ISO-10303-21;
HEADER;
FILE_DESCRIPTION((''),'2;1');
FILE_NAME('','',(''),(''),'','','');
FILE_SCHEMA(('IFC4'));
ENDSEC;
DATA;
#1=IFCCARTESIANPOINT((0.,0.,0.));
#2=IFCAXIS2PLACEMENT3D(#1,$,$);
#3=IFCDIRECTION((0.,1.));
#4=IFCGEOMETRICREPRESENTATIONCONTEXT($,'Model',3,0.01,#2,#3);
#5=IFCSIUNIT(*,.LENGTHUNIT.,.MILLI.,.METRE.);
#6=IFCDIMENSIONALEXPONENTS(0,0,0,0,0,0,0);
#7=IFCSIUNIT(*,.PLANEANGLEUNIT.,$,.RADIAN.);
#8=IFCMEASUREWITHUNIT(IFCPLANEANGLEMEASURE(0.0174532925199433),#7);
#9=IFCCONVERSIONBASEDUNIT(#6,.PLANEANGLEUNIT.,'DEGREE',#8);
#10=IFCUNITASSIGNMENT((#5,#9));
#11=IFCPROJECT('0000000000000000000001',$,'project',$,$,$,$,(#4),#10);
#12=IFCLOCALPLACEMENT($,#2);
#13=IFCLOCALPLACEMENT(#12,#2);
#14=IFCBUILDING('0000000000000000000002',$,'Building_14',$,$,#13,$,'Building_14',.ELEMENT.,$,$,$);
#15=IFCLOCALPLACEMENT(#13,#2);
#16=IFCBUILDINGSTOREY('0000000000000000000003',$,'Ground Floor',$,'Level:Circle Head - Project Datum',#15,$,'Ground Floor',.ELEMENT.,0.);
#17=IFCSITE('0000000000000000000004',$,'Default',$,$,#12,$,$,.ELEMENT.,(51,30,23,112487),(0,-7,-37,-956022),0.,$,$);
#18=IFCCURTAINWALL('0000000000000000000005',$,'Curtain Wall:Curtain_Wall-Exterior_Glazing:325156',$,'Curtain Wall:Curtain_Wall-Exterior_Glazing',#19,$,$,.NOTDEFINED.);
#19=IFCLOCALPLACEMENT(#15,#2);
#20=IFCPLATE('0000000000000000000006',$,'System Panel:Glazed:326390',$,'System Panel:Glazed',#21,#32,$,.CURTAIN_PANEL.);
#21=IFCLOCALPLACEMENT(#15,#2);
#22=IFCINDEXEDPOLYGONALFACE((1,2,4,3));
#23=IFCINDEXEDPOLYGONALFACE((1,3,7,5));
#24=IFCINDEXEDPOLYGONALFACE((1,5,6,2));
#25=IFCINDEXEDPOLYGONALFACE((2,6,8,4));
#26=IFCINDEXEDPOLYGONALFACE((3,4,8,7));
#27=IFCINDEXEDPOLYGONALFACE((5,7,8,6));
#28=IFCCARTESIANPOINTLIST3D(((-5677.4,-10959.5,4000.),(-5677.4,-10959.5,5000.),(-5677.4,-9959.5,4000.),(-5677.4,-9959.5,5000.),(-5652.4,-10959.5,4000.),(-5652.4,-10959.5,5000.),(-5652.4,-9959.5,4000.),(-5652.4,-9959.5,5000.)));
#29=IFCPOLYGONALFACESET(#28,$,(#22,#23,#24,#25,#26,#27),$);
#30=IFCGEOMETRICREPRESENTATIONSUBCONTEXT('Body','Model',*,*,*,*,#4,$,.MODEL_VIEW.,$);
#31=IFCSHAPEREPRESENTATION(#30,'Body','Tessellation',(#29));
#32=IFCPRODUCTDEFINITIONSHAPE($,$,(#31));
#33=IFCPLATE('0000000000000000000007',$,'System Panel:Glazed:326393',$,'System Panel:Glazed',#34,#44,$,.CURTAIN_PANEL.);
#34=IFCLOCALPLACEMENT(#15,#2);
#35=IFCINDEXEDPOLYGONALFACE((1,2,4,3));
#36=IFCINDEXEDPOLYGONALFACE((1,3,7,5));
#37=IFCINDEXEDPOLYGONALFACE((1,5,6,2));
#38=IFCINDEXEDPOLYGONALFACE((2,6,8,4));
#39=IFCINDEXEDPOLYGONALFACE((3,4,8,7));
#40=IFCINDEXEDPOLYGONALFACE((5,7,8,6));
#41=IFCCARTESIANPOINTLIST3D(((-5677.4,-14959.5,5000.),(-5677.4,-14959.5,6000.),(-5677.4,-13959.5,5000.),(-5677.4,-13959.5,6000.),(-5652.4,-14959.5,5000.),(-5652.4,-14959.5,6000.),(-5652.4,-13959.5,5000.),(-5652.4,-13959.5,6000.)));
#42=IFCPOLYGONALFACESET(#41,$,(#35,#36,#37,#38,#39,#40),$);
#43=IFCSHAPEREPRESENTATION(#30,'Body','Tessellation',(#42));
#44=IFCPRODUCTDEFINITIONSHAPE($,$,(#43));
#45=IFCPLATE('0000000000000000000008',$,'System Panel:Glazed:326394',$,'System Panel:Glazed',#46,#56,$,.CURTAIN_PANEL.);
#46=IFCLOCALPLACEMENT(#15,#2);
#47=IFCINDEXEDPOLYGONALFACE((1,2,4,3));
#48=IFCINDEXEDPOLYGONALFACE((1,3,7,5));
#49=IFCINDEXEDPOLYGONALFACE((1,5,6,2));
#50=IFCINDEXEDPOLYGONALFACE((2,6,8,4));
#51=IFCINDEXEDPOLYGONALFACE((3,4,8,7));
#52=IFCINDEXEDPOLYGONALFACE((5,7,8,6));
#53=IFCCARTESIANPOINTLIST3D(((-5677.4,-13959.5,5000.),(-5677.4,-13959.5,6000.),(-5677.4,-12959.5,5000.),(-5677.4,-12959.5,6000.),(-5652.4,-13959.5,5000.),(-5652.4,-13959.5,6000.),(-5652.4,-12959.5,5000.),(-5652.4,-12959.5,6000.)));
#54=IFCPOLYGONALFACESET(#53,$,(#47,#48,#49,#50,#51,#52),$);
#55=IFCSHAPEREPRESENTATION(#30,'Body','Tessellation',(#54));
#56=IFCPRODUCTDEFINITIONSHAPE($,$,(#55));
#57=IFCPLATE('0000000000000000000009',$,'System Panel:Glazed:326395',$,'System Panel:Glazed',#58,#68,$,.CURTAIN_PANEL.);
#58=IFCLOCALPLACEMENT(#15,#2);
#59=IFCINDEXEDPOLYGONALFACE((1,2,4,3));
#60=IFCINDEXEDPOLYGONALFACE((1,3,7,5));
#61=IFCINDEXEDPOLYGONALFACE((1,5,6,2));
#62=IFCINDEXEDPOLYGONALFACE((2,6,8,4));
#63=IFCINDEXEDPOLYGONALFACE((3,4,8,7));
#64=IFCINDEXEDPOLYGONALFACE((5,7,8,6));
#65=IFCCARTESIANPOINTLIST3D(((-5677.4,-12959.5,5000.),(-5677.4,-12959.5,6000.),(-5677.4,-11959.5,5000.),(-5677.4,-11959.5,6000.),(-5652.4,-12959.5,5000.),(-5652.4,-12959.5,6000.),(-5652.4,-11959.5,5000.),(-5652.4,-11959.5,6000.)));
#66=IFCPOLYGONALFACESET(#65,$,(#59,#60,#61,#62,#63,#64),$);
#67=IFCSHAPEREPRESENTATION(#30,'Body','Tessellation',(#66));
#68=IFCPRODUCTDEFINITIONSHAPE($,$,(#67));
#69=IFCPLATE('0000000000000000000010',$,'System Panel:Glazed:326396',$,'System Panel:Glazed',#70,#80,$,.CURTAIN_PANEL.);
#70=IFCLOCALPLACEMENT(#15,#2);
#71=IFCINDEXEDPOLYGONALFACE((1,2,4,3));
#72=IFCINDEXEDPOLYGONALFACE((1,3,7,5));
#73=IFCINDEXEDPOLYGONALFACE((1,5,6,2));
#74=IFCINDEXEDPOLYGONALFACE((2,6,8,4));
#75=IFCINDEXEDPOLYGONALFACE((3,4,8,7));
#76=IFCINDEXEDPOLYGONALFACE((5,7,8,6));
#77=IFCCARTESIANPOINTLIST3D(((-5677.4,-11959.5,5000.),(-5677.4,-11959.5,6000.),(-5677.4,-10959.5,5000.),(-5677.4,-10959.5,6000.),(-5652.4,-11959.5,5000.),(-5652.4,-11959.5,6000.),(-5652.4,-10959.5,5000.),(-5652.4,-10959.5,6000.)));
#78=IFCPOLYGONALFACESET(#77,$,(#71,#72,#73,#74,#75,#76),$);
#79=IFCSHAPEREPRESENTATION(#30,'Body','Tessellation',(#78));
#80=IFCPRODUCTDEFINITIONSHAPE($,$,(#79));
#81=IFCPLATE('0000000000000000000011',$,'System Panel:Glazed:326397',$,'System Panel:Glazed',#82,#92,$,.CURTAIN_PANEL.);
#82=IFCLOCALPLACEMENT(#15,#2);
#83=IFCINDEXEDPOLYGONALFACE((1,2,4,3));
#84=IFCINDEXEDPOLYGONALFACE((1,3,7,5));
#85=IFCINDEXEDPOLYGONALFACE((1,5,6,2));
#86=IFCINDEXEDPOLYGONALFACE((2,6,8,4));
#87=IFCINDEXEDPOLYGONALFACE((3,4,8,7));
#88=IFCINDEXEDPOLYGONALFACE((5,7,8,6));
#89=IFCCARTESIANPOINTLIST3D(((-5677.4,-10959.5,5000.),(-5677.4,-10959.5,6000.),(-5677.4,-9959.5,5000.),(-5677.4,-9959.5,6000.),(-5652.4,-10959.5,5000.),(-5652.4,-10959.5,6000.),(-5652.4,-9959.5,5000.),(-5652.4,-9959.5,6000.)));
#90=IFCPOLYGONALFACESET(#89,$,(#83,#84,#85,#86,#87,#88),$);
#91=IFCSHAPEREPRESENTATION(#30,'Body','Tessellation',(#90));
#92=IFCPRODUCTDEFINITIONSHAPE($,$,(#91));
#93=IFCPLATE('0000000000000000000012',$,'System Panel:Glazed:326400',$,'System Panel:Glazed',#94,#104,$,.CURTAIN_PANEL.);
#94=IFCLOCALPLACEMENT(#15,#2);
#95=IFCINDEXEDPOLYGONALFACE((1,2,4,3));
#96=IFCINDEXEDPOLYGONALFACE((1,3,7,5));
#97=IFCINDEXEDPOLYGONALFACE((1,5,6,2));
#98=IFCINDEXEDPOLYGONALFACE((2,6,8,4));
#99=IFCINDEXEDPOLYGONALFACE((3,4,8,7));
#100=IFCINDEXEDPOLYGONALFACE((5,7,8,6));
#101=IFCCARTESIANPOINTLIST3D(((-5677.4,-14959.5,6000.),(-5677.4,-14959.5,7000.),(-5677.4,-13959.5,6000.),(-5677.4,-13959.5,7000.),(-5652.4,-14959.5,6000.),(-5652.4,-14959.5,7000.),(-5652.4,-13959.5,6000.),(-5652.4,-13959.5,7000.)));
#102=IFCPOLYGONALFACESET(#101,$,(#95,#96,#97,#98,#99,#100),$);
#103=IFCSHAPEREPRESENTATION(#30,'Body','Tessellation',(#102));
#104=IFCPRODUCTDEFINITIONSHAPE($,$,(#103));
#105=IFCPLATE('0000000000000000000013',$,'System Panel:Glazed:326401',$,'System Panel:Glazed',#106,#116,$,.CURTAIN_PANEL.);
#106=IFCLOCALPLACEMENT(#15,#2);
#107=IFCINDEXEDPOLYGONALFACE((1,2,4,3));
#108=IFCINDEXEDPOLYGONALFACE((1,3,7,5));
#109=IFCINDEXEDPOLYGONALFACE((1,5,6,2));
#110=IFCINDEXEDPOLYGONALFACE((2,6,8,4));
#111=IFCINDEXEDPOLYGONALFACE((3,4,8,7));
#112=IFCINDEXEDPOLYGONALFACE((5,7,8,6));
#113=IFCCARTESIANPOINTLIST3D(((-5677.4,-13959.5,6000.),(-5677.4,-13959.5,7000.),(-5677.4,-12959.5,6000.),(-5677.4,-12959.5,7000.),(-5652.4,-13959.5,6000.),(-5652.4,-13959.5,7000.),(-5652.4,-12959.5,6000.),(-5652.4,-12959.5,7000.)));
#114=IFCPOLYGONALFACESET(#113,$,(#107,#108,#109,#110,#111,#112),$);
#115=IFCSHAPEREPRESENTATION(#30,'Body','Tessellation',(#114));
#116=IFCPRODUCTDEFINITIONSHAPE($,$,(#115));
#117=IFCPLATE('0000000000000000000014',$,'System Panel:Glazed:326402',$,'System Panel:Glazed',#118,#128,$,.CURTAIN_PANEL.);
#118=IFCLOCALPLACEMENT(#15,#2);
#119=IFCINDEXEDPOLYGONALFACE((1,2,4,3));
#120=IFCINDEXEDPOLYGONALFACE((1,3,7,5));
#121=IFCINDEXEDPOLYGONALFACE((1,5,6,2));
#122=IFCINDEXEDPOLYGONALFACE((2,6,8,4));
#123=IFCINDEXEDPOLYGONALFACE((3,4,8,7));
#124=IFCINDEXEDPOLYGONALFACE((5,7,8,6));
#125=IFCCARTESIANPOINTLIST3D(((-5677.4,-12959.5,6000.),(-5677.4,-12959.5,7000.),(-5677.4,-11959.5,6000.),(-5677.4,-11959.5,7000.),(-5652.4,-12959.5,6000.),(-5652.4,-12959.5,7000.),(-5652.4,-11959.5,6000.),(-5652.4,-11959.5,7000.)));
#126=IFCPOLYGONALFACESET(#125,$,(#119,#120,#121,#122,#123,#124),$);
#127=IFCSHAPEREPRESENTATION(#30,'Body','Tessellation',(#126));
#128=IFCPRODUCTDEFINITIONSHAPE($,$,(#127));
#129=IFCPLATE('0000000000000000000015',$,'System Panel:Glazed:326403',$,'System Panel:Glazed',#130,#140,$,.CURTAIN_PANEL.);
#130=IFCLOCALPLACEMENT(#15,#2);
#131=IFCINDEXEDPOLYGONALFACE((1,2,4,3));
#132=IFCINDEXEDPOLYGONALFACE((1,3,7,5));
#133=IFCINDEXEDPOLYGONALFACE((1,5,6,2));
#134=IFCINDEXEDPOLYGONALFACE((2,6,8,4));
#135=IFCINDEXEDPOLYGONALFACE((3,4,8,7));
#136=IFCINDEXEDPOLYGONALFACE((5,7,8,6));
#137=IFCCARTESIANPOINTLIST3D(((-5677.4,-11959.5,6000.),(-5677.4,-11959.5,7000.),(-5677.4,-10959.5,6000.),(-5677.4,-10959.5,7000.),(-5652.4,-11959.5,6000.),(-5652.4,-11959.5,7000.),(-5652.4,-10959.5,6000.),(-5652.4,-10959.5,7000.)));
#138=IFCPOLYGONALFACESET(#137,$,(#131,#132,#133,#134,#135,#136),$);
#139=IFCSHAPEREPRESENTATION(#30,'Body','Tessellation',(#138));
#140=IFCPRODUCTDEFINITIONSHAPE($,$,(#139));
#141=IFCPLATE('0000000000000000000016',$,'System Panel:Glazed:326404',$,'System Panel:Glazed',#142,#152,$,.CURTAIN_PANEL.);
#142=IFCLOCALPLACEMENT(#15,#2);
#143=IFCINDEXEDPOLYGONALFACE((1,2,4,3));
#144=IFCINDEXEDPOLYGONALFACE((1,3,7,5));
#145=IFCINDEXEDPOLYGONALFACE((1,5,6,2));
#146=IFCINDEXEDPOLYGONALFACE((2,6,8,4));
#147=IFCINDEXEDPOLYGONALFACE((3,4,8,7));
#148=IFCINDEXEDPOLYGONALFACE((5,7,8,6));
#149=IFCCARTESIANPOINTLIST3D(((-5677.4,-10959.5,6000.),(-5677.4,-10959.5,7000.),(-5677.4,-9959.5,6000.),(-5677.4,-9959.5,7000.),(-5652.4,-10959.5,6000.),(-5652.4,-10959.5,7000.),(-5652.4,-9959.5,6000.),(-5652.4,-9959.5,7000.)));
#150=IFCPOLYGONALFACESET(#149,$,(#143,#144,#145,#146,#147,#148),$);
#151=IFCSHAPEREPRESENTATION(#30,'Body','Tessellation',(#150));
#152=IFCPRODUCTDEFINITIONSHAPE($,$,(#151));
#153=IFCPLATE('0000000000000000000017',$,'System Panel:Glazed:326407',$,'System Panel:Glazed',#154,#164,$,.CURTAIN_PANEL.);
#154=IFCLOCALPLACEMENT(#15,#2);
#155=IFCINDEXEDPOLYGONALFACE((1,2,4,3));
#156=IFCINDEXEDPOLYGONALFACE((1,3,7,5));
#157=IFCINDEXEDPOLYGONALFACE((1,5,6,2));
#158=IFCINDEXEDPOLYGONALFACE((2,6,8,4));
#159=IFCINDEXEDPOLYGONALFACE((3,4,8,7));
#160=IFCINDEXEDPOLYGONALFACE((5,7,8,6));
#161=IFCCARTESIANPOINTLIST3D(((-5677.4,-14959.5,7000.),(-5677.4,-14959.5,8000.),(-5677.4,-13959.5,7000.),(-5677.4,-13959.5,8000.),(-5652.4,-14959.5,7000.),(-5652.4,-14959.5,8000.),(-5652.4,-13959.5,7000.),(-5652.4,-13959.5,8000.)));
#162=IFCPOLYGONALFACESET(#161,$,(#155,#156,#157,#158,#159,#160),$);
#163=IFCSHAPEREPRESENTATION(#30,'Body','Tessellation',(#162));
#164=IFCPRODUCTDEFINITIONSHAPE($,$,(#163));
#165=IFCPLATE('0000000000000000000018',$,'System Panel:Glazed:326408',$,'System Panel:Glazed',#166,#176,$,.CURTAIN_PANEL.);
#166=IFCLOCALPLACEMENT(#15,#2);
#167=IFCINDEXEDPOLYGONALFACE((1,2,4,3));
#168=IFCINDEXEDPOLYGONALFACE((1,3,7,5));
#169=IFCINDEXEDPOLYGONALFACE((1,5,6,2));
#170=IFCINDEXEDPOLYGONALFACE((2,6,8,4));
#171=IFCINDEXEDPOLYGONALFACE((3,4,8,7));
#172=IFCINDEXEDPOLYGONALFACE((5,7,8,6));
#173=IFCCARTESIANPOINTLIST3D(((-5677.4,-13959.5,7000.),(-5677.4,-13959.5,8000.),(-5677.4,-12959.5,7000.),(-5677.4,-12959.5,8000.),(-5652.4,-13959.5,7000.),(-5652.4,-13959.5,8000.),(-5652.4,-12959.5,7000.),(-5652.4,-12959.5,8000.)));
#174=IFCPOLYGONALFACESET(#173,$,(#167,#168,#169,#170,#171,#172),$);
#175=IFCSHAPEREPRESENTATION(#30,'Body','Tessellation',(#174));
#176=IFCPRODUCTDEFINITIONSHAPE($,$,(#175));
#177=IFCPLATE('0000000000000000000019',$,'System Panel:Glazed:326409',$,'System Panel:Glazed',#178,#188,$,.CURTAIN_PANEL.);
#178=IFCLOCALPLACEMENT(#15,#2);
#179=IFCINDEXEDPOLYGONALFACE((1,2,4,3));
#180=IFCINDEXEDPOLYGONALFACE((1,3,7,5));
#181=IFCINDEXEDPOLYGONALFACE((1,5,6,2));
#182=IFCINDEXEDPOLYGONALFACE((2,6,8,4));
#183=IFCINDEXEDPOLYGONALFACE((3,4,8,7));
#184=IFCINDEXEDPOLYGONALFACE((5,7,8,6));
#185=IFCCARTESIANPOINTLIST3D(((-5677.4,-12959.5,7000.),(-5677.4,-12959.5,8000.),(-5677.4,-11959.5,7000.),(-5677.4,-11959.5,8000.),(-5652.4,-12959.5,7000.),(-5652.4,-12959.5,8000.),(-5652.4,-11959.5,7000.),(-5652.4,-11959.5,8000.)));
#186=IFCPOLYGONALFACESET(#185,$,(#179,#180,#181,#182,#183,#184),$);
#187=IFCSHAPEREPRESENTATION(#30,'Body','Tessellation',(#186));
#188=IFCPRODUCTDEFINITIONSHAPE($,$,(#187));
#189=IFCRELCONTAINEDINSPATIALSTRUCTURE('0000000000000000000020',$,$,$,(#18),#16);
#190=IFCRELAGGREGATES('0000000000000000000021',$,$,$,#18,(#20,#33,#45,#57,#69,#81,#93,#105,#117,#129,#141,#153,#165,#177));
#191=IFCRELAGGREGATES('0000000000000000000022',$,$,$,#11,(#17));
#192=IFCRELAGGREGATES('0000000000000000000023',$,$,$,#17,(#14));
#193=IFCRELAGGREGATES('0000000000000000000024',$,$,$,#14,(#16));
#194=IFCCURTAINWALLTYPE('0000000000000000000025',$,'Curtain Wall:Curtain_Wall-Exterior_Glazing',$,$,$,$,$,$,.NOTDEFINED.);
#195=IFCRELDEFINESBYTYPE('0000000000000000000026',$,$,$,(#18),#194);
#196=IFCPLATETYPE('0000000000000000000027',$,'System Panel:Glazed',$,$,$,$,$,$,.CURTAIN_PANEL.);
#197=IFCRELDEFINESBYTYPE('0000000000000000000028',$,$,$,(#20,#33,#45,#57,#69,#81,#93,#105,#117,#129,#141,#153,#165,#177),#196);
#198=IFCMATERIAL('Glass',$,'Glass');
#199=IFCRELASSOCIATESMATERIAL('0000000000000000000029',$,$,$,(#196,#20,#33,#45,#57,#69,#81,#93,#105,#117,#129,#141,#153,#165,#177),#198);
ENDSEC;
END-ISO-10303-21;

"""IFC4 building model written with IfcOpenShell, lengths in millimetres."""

from ifc_helpers import new_model, entity, si_unit, converted_unit, direction, frame, origin, place, context, subcontext, project, spatial, indexed_curve, outline, extrude, source, transform, mapped, material, type_object, type_shapes, element, aggregate, save


model = new_model("IFC4")

# Units and contexts
model_context = context("Model", 3, precision=0.01, world=origin(), true_north=direction((0.0, 1.0)))
body_context = subcontext(model_context, "Body", "Model", "MODEL_VIEW")
ifc_project = project(units=[si_unit("LENGTHUNIT", "METRE", prefix="MILLI"), converted_unit("PLANEANGLEUNIT", "DEGREE", entity("IfcPlaneAngleMeasure", 0.0174532925199433), si_unit("PLANEANGLEUNIT", "RADIAN"), dimensions=[0, 0, 0, 0, 0, 0, 0])], contexts=[model_context])

# Site, building, storey
site_placement = place(None, origin())
site = spatial("IfcSite", under=ifc_project, at=site_placement, Name="Default", CompositionType="ELEMENT", RefLatitude=(51, 30, 23, 112487), RefLongitude=(0, -7, -37, -956022), RefElevation=0.0)
building_placement = place(site_placement, origin())
building = spatial("IfcBuilding", under=site, at=building_placement, Name="Building_14", LongName="Building_14", CompositionType="ELEMENT")
storey_placement = place(building_placement, origin())
storey = spatial("IfcBuildingStorey", under=building, at=storey_placement, Name="Ground Floor", ObjectType="Level:Circle Head - Project Datum", LongName="Ground Floor", CompositionType="ELEMENT", Elevation=0.0)

# Curtain wall, plates
curtain_wall_type = type_object("IfcCurtainWallType", Name="Curtain Wall:Curtain_Wall-Exterior_Glazing", PredefinedType="NOTDEFINED")
curtain_wall_1_placement = place(storey_placement, origin())
curtain_wall_1 = element("IfcCurtainWall", 1, at=curtain_wall_1_placement, inside=storey, type_object=curtain_wall_type, Name="Curtain Wall:Curtain_Wall-Exterior_Glazing:325156", ObjectType="Curtain Wall:Curtain_Wall-Exterior_Glazing", PredefinedType="NOTDEFINED")
ifc_material = material(Name="Glass", Category="Glass")
plate_type_1 = type_object("IfcPlateType", Name="System Panel:Glazed", PredefinedType="CURTAIN_PANEL", material=ifc_material)
shared_shape_1 = source(origin(), body_context, "Body", "SweptSolid", [
    extrude(outline(indexed_curve([(-12.5, -500.0), (12.5, -500.0), (12.5, 500.0), (-12.5, 500.0), (-12.5, -500.0)], self_intersect=False)), frame((0.0, -37.0, 0.0), z_axis=(0.0, 0.0, 1.0), x_axis=(0.0, 1.0, 0.0)), (0.0, 0.0, 1.0), 1000.0),
])
type_shapes(plate_type_1, [shared_shape_1])
plate_1_placement = place(curtain_wall_1_placement, frame((-5701.9, -10459.5, 4000.0), z_axis=(0.0, 0.0, 1.0), x_axis=(0.0, 1.0, 0.0)))
plate_1 = element("IfcPlate", 2, at=plate_1_placement, type_object=plate_type_1, material=ifc_material, Name="System Panel:Glazed:326390", ObjectType="System Panel:Glazed", PredefinedType="CURTAIN_PANEL", context=body_context, shape_type="MappedRepresentation", body=[
    mapped(shared_shape_1, transform((0.0, 0.0, 0.0), scale=1.0)),
])
plate_2_placement = place(curtain_wall_1_placement, frame((-5701.9, -14459.5, 5000.0), z_axis=(0.0, 0.0, 1.0), x_axis=(0.0, 1.0, 0.0)))
plate_2 = element("IfcPlate", 3, at=plate_2_placement, type_object=plate_type_1, material=ifc_material, Name="System Panel:Glazed:326393", ObjectType="System Panel:Glazed", PredefinedType="CURTAIN_PANEL", context=body_context, shape_type="MappedRepresentation", body=[
    mapped(shared_shape_1, transform((0.0, 0.0, 0.0), scale=1.0)),
])
plate_3_placement = place(curtain_wall_1_placement, frame((-5701.9, -13459.5, 5000.0), z_axis=(0.0, 0.0, 1.0), x_axis=(0.0, 1.0, 0.0)))
plate_3 = element("IfcPlate", 4, at=plate_3_placement, type_object=plate_type_1, material=ifc_material, Name="System Panel:Glazed:326394", ObjectType="System Panel:Glazed", PredefinedType="CURTAIN_PANEL", context=body_context, shape_type="MappedRepresentation", body=[
    mapped(shared_shape_1, transform((0.0, 0.0, 0.0), scale=1.0)),
])
plate_4_placement = place(curtain_wall_1_placement, frame((-5701.9, -12459.5, 5000.0), z_axis=(0.0, 0.0, 1.0), x_axis=(0.0, 1.0, 0.0)))
plate_4 = element("IfcPlate", 5, at=plate_4_placement, type_object=plate_type_1, material=ifc_material, Name="System Panel:Glazed:326395", ObjectType="System Panel:Glazed", PredefinedType="CURTAIN_PANEL", context=body_context, shape_type="MappedRepresentation", body=[
    mapped(shared_shape_1, transform((0.0, 0.0, 0.0), scale=1.0)),
])
plate_5_placement = place(curtain_wall_1_placement, frame((-5701.9, -11459.5, 5000.0), z_axis=(0.0, 0.0, 1.0), x_axis=(0.0, 1.0, 0.0)))
plate_5 = element("IfcPlate", 6, at=plate_5_placement, type_object=plate_type_1, material=ifc_material, Name="System Panel:Glazed:326396", ObjectType="System Panel:Glazed", PredefinedType="CURTAIN_PANEL", context=body_context, shape_type="MappedRepresentation", body=[
    mapped(shared_shape_1, transform((0.0, 0.0, 0.0), scale=1.0)),
])
plate_6_placement = place(curtain_wall_1_placement, frame((-5701.9, -10459.5, 5000.0), z_axis=(0.0, 0.0, 1.0), x_axis=(0.0, 1.0, 0.0)))
plate_6 = element("IfcPlate", 7, at=plate_6_placement, type_object=plate_type_1, material=ifc_material, Name="System Panel:Glazed:326397", ObjectType="System Panel:Glazed", PredefinedType="CURTAIN_PANEL", context=body_context, shape_type="MappedRepresentation", body=[
    mapped(shared_shape_1, transform((0.0, 0.0, 0.0), scale=1.0)),
])
plate_7_placement = place(curtain_wall_1_placement, frame((-5701.9, -14459.5, 6000.0), z_axis=(0.0, 0.0, 1.0), x_axis=(0.0, 1.0, 0.0)))
plate_7 = element("IfcPlate", 8, at=plate_7_placement, type_object=plate_type_1, material=ifc_material, Name="System Panel:Glazed:326400", ObjectType="System Panel:Glazed", PredefinedType="CURTAIN_PANEL", context=body_context, shape_type="MappedRepresentation", body=[
    mapped(shared_shape_1, transform((0.0, 0.0, 0.0), scale=1.0)),
])
plate_8_placement = place(curtain_wall_1_placement, frame((-5701.9, -13459.5, 6000.0), z_axis=(0.0, 0.0, 1.0), x_axis=(0.0, 1.0, 0.0)))
plate_8 = element("IfcPlate", 9, at=plate_8_placement, type_object=plate_type_1, material=ifc_material, Name="System Panel:Glazed:326401", ObjectType="System Panel:Glazed", PredefinedType="CURTAIN_PANEL", context=body_context, shape_type="MappedRepresentation", body=[
    mapped(shared_shape_1, transform((0.0, 0.0, 0.0), scale=1.0)),
])
plate_9_placement = place(curtain_wall_1_placement, frame((-5701.9, -12459.5, 6000.0), z_axis=(0.0, 0.0, 1.0), x_axis=(0.0, 1.0, 0.0)))
plate_9 = element("IfcPlate", 10, at=plate_9_placement, type_object=plate_type_1, material=ifc_material, Name="System Panel:Glazed:326402", ObjectType="System Panel:Glazed", PredefinedType="CURTAIN_PANEL", context=body_context, shape_type="MappedRepresentation", body=[
    mapped(shared_shape_1, transform((0.0, 0.0, 0.0), scale=1.0)),
])
plate_10_placement = place(curtain_wall_1_placement, frame((-5701.9, -11459.5, 6000.0), z_axis=(0.0, 0.0, 1.0), x_axis=(0.0, 1.0, 0.0)))
plate_10 = element("IfcPlate", 11, at=plate_10_placement, type_object=plate_type_1, material=ifc_material, Name="System Panel:Glazed:326403", ObjectType="System Panel:Glazed", PredefinedType="CURTAIN_PANEL", context=body_context, shape_type="MappedRepresentation", body=[
    mapped(shared_shape_1, transform((0.0, 0.0, 0.0), scale=1.0)),
])
plate_11_placement = place(curtain_wall_1_placement, frame((-5701.9, -10459.5, 6000.0), z_axis=(0.0, 0.0, 1.0), x_axis=(0.0, 1.0, 0.0)))
plate_11 = element("IfcPlate", 12, at=plate_11_placement, type_object=plate_type_1, material=ifc_material, Name="System Panel:Glazed:326404", ObjectType="System Panel:Glazed", PredefinedType="CURTAIN_PANEL", context=body_context, shape_type="MappedRepresentation", body=[
    mapped(shared_shape_1, transform((0.0, 0.0, 0.0), scale=1.0)),
])
plate_12_placement = place(curtain_wall_1_placement, frame((-5701.9, -14459.5, 7000.0), z_axis=(0.0, 0.0, 1.0), x_axis=(0.0, 1.0, 0.0)))
plate_12 = element("IfcPlate", 13, at=plate_12_placement, type_object=plate_type_1, material=ifc_material, Name="System Panel:Glazed:326407", ObjectType="System Panel:Glazed", PredefinedType="CURTAIN_PANEL", context=body_context, shape_type="MappedRepresentation", body=[
    mapped(shared_shape_1, transform((0.0, 0.0, 0.0), scale=1.0)),
])
plate_13_placement = place(curtain_wall_1_placement, frame((-5701.9, -13459.5, 7000.0), z_axis=(0.0, 0.0, 1.0), x_axis=(0.0, 1.0, 0.0)))
plate_13 = element("IfcPlate", 14, at=plate_13_placement, type_object=plate_type_1, material=ifc_material, Name="System Panel:Glazed:326408", ObjectType="System Panel:Glazed", PredefinedType="CURTAIN_PANEL", context=body_context, shape_type="MappedRepresentation", body=[
    mapped(shared_shape_1, transform((0.0, 0.0, 0.0), scale=1.0)),
])
plate_14_placement = place(curtain_wall_1_placement, frame((-5701.9, -12459.5, 7000.0), z_axis=(0.0, 0.0, 1.0), x_axis=(0.0, 1.0, 0.0)))
plate_14 = element("IfcPlate", 15, at=plate_14_placement, type_object=plate_type_1, material=ifc_material, Name="System Panel:Glazed:326409", ObjectType="System Panel:Glazed", PredefinedType="CURTAIN_PANEL", context=body_context, shape_type="MappedRepresentation", body=[
    mapped(shared_shape_1, transform((0.0, 0.0, 0.0), scale=1.0)),
])
aggregate(curtain_wall_1, [plate_1, plate_2, plate_3, plate_4, plate_5, plate_6, plate_7, plate_8, plate_9, plate_10, plate_11, plate_12, plate_13, plate_14])

save(model, "model.ifc")
